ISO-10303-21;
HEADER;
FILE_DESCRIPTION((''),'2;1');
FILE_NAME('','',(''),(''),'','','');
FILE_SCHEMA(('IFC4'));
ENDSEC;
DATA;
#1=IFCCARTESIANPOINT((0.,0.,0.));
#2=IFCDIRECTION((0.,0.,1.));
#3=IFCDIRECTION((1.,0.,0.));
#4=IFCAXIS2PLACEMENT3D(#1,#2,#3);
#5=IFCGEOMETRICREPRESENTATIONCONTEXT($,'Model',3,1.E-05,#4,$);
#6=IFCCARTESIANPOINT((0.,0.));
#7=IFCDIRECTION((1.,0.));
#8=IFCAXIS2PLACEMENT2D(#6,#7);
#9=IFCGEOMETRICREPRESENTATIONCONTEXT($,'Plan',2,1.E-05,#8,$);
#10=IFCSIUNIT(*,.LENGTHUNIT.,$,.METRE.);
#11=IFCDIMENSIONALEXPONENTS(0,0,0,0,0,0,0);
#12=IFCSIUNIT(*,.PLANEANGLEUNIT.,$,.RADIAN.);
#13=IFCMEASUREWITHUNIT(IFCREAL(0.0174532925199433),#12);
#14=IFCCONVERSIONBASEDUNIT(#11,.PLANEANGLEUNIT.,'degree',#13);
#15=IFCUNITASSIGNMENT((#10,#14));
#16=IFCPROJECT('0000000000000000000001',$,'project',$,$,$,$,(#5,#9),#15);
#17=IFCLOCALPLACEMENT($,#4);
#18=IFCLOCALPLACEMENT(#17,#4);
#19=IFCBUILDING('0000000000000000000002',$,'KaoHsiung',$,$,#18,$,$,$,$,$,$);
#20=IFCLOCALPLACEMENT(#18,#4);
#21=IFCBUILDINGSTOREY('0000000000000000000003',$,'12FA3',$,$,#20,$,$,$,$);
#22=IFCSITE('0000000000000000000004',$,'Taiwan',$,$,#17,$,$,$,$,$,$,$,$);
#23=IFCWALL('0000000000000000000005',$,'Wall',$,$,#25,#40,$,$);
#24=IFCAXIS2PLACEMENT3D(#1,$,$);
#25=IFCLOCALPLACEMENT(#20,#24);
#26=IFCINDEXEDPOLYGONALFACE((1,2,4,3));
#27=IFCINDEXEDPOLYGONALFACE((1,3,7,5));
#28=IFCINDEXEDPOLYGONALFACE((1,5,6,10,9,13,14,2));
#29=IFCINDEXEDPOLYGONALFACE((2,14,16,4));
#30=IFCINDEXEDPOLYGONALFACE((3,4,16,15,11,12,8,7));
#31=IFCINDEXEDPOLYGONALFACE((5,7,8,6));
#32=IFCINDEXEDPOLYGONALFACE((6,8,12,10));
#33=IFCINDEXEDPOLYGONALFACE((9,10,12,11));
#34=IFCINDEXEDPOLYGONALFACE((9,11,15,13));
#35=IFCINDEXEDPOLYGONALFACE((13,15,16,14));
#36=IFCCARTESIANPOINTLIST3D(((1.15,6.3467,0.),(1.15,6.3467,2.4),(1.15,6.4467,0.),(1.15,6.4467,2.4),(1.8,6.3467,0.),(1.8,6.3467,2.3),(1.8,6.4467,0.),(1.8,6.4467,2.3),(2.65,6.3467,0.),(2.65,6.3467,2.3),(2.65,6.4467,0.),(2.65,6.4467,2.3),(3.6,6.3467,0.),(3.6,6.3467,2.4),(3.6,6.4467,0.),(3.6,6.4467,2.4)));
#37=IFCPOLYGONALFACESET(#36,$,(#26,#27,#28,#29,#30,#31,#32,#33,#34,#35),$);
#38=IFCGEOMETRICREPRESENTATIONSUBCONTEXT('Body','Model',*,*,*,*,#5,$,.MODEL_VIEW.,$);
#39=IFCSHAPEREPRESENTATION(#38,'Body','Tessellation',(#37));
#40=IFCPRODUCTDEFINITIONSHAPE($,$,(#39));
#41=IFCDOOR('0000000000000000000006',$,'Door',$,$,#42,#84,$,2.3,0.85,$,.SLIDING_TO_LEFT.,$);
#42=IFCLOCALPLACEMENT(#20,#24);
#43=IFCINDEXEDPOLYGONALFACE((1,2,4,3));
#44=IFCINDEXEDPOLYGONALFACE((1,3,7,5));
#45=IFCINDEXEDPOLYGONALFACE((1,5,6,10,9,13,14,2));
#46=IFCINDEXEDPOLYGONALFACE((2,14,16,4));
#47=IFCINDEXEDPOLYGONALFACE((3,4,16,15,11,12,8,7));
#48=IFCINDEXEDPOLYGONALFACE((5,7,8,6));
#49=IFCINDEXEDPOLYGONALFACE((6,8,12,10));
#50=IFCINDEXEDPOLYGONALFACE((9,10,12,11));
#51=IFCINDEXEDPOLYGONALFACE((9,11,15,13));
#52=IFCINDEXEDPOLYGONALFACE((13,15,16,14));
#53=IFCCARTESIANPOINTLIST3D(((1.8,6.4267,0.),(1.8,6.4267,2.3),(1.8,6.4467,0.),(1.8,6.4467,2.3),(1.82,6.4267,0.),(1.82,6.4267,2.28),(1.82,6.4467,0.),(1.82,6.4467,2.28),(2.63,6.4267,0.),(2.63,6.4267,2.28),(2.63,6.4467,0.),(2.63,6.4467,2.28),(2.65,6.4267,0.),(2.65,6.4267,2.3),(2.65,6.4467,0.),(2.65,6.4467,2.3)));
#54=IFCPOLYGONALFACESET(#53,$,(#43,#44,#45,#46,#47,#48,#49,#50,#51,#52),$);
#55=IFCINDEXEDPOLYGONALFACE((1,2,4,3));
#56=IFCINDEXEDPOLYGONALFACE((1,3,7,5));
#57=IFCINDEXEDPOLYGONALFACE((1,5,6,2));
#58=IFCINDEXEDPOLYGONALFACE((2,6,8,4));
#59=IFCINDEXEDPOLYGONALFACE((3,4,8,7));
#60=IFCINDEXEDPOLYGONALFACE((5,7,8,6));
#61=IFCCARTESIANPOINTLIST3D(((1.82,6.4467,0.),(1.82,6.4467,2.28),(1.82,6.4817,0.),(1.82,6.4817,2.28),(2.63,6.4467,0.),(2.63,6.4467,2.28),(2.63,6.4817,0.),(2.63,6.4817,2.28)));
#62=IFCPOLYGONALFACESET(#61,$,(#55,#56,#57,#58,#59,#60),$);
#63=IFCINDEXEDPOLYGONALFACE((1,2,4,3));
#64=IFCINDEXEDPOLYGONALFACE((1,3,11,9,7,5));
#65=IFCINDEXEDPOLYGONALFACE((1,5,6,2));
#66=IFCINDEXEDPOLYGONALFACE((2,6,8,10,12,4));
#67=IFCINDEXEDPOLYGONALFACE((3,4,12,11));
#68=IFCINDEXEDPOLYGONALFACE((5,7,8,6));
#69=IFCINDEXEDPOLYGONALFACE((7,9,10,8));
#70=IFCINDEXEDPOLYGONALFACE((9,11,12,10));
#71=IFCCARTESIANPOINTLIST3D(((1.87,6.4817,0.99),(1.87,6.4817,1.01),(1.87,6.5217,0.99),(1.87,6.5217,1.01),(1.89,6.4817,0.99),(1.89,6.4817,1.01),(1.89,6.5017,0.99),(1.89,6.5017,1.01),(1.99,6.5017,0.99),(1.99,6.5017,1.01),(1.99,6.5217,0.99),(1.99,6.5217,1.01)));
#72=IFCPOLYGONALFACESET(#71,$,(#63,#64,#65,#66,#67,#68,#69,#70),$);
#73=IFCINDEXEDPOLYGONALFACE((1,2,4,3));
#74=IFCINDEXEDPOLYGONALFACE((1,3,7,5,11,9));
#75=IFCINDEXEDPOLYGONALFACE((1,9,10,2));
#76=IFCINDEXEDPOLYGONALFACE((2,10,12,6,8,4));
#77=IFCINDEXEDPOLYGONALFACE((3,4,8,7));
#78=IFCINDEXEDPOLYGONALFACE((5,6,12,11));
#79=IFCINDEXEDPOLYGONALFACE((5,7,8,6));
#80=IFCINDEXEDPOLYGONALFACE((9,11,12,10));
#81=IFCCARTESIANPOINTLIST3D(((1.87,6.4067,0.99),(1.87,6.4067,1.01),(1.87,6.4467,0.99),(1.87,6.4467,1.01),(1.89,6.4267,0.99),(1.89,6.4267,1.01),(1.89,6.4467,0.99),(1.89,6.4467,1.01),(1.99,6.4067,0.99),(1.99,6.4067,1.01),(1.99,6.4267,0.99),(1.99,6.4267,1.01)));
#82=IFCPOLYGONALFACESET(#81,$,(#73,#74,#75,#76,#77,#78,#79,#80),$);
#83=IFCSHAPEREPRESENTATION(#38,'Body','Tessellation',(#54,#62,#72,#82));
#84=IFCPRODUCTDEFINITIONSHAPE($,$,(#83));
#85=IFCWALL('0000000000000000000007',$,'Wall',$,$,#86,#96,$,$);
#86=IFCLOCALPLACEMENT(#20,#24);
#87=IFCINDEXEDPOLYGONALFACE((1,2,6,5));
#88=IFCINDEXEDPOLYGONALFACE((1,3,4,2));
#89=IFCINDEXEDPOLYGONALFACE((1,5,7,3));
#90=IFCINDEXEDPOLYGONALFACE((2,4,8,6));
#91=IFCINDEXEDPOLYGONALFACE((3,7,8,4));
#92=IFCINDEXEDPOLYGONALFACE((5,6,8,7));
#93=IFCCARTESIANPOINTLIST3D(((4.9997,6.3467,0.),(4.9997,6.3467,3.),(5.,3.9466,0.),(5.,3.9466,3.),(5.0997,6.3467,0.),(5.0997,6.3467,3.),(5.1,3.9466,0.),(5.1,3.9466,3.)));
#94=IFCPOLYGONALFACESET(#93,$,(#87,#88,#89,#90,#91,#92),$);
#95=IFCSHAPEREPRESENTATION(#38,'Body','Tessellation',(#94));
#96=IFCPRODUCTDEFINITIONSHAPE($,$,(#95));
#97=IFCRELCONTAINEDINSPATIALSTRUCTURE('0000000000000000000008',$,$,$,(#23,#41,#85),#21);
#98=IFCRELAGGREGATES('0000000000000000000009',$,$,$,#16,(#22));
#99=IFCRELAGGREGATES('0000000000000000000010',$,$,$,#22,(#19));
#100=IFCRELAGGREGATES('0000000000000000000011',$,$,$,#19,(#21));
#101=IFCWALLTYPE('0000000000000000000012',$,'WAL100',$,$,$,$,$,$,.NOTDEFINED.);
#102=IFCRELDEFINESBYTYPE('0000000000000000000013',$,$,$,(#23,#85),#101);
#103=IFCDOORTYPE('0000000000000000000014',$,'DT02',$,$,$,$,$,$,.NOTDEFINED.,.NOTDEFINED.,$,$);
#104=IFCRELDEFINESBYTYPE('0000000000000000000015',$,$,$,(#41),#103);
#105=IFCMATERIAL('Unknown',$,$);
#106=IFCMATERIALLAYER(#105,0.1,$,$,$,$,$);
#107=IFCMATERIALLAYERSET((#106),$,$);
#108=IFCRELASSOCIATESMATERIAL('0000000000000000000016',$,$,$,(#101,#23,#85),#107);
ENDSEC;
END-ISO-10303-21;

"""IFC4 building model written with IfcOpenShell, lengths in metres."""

from ifc_helpers import new_model, entity, si_unit, converted_unit, frame, origin_with_axes, origin_2d_with_axis, place, context, subcontext, project, spatial, line, indexed_curve, outline, extrude, shape, source, transform, mapped, material, layer, layer_set, layer_usage, type_object, type_shapes, element, fill, save


model = new_model("IFC4")

# Units and contexts
model_context = context("Model", 3, precision=1e-05, world=origin_with_axes())
plan_context = context("Plan", 2, precision=1e-05, world=origin_2d_with_axis())
body_context_1 = subcontext(model_context, "Body", "Model", "MODEL_VIEW")
body_context_2 = subcontext(plan_context, "Body", "Plan", "PLAN_VIEW")
ifc_project = project(units=[si_unit("LENGTHUNIT", "METRE"), converted_unit("PLANEANGLEUNIT", "degree", entity("IfcReal", 0.0174532925199433), si_unit("PLANEANGLEUNIT", "RADIAN"), dimensions=[0, 0, 0, 0, 0, 0, 0])], contexts=[model_context, plan_context])

# Site, building, storey
site_placement = place(None, origin_with_axes())
site = spatial("IfcSite", under=ifc_project, at=site_placement, Name="Taiwan")
building_placement = place(site_placement, origin_with_axes())
building = spatial("IfcBuilding", under=site, at=building_placement, Name="KaoHsiung")
storey_placement = place(building_placement, origin_with_axes())
storey = spatial("IfcBuildingStorey", under=building, at=storey_placement, Name="12FA3")

# Shared definitions
ifc_material = material(Name="Unknown")

# Shared definitions
ifc_layer_1 = layer(ifc_material, 0.1)
ifc_layer_set_1 = layer_set([ifc_layer_1])
wall_type_1 = type_object("IfcWallType", Name="WAL100", PredefinedType="NOTDEFINED", material=ifc_layer_set_1)

# Wall, opening, door
ifc_layer_usage_1 = layer_usage(ifc_layer_set_1, "AXIS2", "POSITIVE", 0.0)
wall_1_placement = place(storey_placement, frame((3.6, 6.4467, 0.0), z_axis=(0.0, 0.0, 1.0), x_axis=(-1.0, 0.0, 0.0)))
wall_1 = element("IfcWall", 1, at=wall_1_placement, inside=storey, type_object=wall_type_1, material=ifc_layer_usage_1, Name="Wall", context=body_context_1, shape_type="SweptSolid", body=[
    extrude(outline(indexed_curve([(0.0, 0.0), (0.0, 0.1), (2.45, 0.1), (2.45, 0.0)], segments=[line(1, 2, 3, 4, 1)])), origin_with_axes(), (0.0, 0.0, 1.0), 2.4),
])
shared_shape_1 = source(origin_with_axes(), body_context_1, "Body", "SweptSolid", [
    extrude(outline(indexed_curve([(0.0, 0.0), (0.85, 0.0), (0.85, 2.3), (0.0, 2.3)], segments=[line(1, 2, 3, 4, 1)])), frame((0.0, -0.6, 0.0), z_axis=(0.0, -1.0, 0.0), x_axis=(1.0, 0.0, 0.0)), (0.0, 0.0, -1.0), 1.2),
])
opening_1_placement = place(wall_1_placement, frame((0.95, 0.0, 0.0), z_axis=(0.0, 0.0, 1.0), x_axis=(1.0, 0.0, 0.0)))
opening_1 = element("IfcOpeningElement", 2, at=opening_1_placement, cuts=wall_1, PredefinedType="OPENING", context=body_context_1, shape_type="MappedRepresentation", body=[
    mapped(shared_shape_1, transform((0.0, 0.0, 0.0), x_axis=(1.0, 0.0, 0.0), y_axis=(0.0, 1.0, 0.0), z_axis=(0.0, 0.0, 1.0), scale=1.0)),
])
door_type_1 = type_object("IfcDoorType", Name="DT02", OperationType="NOTDEFINED", PredefinedType="NOTDEFINED")
shared_shape_2 = source(origin_with_axes(), body_context_1, "Body", "SweptSolid", [
    extrude(outline(indexed_curve([(0.0, 0.0), (0.0, 2.3), (0.85, 2.3), (0.85, 0.0), (0.83, 0.0), (0.83, 2.28), (0.02, 2.28), (0.02, 0.0)], segments=[line(1, 2, 3, 4, 5, 6, 7, 8, 1)])), frame((0.0, 0.0, 0.0), z_axis=(0.0, -1.0, 0.0), x_axis=(1.0, 0.0, 0.0)), (0.0, 0.0, -1.0), 0.02),
    extrude(outline(indexed_curve([(0.0, 0.0), (0.81, 0.0), (0.81, 0.035), (0.0, 0.035)], segments=[line(1, 2, 3, 4, 1)])), frame((0.02, -0.035, 0.0), z_axis=(0.0, 0.0, 1.0), x_axis=(1.0, 0.0, 0.0)), (0.0, 0.0, 1.0), 2.28),
    extrude(outline(indexed_curve([(0.0, 0.0), (0.0, -0.04), (-0.12, -0.04), (-0.12, -0.02), (-0.02, -0.02), (-0.02, 0.0)], segments=[line(1, 2, 3, 4, 5, 6, 1)])), frame((0.78, -0.035, 0.99), z_axis=(0.0, 0.0, 1.0), x_axis=(1.0, 0.0, 0.0)), (0.0, 0.0, 1.0), 0.02),
    extrude(outline(indexed_curve([(0.0, 0.0), (0.0, 0.04), (-0.12, 0.04), (-0.12, 0.02), (-0.02, 0.02), (-0.02, 0.0)], segments=[line(1, 2, 3, 4, 5, 6, 1)])), frame((0.78, 0.0, 0.99), z_axis=(0.0, 0.0, 1.0), x_axis=(1.0, 0.0, 0.0)), (0.0, 0.0, 1.0), 0.02),
])
shared_shape_3 = source(origin_with_axes(), body_context_2, "Body", "Curve2D", [
    entity("IfcIndexedPolyCurve", entity("IfcCartesianPointList2D", [[0.0, 0.0], [0.02, 0.0], [0.02, 0.02], [0.0, 0.02]]), [entity("IfcLineIndex", [1, 2, 3, 4, 1])]),
    entity("IfcIndexedPolyCurve", entity("IfcCartesianPointList2D", [[0.85, 0.0], [0.83, 0.0], [0.83, 0.02], [0.85, 0.02]]), [entity("IfcLineIndex", [1, 2, 3, 4, 1])]),
    entity("IfcIndexedPolyCurve", entity("IfcCartesianPointList2D", [[-0.385, -0.035], [0.425, -0.035], [0.425, 0.0], [-0.385, 0.0]]), [entity("IfcLineIndex", [1, 2, 3, 4, 1])]),
])
type_shapes(door_type_1, [shared_shape_2, shared_shape_3])
door_1_placement = place(opening_1_placement, frame((0.0, 0.0, 0.0), z_axis=(0.0, 0.0, 1.0), x_axis=(1.0, 0.0, 0.0)))
door_1 = element("IfcDoor", 3, at=door_1_placement, inside=storey, type_object=door_type_1, Name="Door", OperationType="SLIDING_TO_LEFT", OverallHeight=2.3, OverallWidth=0.85, shapes=[
    shape(body_context_1, "Body", "MappedRepresentation", [mapped(shared_shape_2, transform((0.0, 0.0, 0.0), x_axis=(1.0, 0.0, 0.0), y_axis=(0.0, 1.0, 0.0), z_axis=(0.0, 0.0, 1.0), scale=1.0))]),
    shape(body_context_2, "Body", "MappedRepresentation", [mapped(shared_shape_3, transform((0.0, 0.0, 0.0), x_axis=(1.0, 0.0, 0.0), y_axis=(0.0, 1.0, 0.0), z_axis=(0.0, 0.0, 1.0), scale=1.0))]),
])
fill(opening_1, door_1)

# Wall
ifc_layer_usage_2 = layer_usage(ifc_layer_set_1, "AXIS2", "POSITIVE", 0.0)
wall_2_placement = place(storey_placement, frame((4.9997, 6.3467, 0.0), z_axis=(0.0, 0.0, 1.0), x_axis=(0.000135, -1.0, 0.0)))
element("IfcWall", 4, at=wall_2_placement, inside=storey, type_object=wall_type_1, material=ifc_layer_usage_2, Name="Wall", context=body_context_1, shape_type="SweptSolid", body=[
    extrude(outline(indexed_curve([(0.0, 0.0), (0.0, 0.1), (2.4001, 0.1), (2.4001, 0.0)], segments=[line(1, 2, 3, 4, 1)])), origin_with_axes(), (0.0, 0.0, 1.0), 3.0),
])

save(model, "model.ifc")
